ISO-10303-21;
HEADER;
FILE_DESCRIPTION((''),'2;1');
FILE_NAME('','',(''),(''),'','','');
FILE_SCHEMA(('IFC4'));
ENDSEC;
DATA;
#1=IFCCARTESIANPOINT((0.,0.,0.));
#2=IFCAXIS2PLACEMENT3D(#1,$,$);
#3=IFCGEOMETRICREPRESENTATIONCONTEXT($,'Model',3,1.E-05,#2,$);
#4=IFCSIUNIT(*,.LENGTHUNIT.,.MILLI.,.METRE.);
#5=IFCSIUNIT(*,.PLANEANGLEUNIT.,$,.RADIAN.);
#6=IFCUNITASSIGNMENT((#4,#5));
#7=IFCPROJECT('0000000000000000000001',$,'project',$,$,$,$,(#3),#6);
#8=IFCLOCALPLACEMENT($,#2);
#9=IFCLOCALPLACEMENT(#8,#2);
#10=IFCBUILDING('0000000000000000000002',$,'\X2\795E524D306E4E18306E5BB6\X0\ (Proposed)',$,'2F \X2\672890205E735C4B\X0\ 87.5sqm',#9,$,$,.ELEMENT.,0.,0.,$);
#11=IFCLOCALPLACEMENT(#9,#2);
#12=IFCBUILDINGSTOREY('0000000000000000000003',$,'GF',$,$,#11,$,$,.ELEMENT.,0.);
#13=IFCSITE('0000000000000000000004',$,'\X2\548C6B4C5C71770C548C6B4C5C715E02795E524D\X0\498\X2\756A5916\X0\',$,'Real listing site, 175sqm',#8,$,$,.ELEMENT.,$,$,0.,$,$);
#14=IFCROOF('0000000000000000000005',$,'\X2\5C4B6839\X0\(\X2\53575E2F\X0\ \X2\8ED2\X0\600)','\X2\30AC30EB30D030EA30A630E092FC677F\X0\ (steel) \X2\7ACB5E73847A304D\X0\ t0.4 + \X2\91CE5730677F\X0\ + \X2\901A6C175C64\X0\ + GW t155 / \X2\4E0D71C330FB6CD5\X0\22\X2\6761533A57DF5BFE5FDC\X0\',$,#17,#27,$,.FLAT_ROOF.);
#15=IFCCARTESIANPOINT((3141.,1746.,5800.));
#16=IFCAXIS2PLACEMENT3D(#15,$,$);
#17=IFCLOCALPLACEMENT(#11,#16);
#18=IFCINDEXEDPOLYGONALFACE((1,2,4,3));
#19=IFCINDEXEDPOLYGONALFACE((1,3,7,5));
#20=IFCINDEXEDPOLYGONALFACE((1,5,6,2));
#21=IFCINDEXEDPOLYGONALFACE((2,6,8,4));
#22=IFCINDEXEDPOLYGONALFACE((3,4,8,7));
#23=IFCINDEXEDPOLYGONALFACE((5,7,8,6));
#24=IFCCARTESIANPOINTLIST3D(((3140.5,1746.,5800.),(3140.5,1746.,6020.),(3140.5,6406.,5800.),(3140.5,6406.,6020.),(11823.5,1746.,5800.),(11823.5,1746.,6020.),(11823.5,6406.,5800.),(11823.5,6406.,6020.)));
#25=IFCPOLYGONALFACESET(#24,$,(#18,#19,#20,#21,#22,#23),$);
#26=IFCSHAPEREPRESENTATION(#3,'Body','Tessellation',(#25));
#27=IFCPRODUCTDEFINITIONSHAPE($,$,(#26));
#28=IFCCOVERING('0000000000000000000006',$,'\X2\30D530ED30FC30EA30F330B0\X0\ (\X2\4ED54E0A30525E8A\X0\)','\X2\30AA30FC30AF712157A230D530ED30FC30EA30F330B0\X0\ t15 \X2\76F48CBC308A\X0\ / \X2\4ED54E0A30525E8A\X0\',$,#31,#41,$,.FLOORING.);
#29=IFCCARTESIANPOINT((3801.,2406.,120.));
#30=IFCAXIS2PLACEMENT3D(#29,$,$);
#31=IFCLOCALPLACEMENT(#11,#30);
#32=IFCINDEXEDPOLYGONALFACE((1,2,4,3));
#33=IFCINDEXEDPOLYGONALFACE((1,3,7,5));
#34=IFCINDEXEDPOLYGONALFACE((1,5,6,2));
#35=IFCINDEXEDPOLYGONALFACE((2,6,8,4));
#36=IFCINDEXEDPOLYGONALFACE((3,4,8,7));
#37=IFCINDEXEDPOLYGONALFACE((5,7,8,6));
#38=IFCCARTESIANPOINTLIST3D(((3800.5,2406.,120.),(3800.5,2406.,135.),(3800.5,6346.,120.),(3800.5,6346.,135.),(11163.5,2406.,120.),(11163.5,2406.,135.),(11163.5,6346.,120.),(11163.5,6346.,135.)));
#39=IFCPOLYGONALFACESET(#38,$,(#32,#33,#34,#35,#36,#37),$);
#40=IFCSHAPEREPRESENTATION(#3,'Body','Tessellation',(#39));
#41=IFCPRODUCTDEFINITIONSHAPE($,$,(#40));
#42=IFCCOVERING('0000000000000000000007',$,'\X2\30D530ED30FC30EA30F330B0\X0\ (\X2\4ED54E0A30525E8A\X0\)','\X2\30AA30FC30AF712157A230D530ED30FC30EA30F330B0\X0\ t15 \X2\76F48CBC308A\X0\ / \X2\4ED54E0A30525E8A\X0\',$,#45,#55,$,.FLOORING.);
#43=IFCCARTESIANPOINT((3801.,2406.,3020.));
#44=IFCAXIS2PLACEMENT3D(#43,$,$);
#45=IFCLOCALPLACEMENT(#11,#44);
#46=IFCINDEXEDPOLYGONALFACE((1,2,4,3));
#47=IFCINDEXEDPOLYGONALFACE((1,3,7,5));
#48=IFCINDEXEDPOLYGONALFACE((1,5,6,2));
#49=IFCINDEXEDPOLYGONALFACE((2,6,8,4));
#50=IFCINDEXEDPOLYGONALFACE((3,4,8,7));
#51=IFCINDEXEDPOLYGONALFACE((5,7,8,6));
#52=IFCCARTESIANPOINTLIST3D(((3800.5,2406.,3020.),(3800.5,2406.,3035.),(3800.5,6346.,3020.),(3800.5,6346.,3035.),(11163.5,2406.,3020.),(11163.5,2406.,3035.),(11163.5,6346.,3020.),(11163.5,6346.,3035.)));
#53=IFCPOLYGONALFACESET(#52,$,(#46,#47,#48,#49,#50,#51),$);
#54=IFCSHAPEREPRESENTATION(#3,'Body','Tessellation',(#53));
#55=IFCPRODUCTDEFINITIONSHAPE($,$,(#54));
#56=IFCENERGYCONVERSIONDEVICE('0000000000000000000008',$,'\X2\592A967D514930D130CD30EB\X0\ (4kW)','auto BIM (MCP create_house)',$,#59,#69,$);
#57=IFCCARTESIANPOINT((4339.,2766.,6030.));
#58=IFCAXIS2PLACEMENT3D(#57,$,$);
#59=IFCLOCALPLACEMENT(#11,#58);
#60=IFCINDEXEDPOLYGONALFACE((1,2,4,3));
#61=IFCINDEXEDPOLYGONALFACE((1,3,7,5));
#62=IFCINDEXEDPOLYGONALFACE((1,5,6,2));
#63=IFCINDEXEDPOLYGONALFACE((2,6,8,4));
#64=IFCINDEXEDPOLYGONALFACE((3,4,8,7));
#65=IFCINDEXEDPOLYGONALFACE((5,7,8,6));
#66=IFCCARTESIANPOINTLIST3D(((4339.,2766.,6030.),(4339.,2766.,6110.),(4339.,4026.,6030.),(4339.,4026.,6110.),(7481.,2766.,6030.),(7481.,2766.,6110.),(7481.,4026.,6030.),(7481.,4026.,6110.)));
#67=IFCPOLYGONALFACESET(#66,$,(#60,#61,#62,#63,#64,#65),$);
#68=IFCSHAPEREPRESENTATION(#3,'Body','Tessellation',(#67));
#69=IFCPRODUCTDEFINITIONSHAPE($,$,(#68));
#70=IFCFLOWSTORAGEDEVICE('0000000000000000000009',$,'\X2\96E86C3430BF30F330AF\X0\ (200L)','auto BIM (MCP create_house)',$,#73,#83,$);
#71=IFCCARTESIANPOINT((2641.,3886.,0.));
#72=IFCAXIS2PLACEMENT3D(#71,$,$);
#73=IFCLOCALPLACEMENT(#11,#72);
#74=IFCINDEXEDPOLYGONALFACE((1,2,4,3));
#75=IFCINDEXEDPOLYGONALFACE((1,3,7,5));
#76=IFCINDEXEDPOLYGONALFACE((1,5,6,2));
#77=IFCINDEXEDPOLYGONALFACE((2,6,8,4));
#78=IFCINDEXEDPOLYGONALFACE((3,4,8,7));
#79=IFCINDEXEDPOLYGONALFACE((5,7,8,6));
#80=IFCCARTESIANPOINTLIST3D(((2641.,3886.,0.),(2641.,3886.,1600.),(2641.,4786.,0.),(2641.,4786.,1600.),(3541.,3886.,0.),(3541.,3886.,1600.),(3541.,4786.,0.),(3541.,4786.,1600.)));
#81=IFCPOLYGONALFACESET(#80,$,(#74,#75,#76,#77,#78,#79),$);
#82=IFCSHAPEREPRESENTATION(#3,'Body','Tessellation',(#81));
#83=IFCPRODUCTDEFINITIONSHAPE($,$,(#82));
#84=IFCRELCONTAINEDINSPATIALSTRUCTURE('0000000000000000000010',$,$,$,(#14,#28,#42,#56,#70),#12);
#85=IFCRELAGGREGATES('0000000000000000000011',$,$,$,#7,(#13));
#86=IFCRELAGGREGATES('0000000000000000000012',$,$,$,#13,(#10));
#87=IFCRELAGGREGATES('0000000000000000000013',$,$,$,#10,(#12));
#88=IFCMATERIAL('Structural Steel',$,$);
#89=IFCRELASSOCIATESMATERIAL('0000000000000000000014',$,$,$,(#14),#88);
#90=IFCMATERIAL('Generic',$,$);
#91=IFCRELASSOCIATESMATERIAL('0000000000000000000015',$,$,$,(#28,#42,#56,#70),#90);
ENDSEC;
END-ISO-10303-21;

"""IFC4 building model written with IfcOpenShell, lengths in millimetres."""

from ifc_helpers import new_model, si_unit, frame, frame_2d, origin, place, context, project, spatial, rectangle, extrude, material, element, save


model = new_model("IFC4")

# Units and contexts
model_context = context("Model", 3, precision=1e-05, world=origin())
ifc_project = project(units=[si_unit("LENGTHUNIT", "METRE", prefix="MILLI"), si_unit("PLANEANGLEUNIT", "RADIAN")], contexts=[model_context])

# Site, building, storey
site_placement = place(None, origin())
site = spatial("IfcSite", under=ifc_project, at=site_placement, Name="和歌山県和歌山市神前498番外", ObjectType="Real listing site, 175sqm", CompositionType="ELEMENT", RefElevation=0.0)
building_placement = place(site_placement, origin())
building = spatial("IfcBuilding", under=site, at=building_placement, Name="神前の丘の家 (Proposed)", ObjectType="2F 木造平屋 87.5sqm", CompositionType="ELEMENT", ElevationOfRefHeight=0.0, ElevationOfTerrain=0.0)
storey_placement = place(building_placement, origin())
storey = spatial("IfcBuildingStorey", under=building, at=storey_placement, Name="GF", CompositionType="ELEMENT", Elevation=0.0)

# Roof
ifc_material_1 = material(Name="Structural Steel")
for number, where, name in (
    (1, (3141.0, 1746.0, 5800.0), "屋根(南帯 軒600)"),
):
    element("IfcRoof", number, at=place(storey_placement, frame(where)), inside=storey, material=ifc_material_1, Name=name, Description="ガルバリウム鋼板 (steel) 立平葺き t0.4 + 野地板 + 通気層 + GW t155 / 不燃・法22条区域対応", PredefinedType="FLAT_ROOF", context=model_context, shape_type="SweptSolid", body=[
        extrude(rectangle(XDim=8683.0, YDim=4660.0, at=frame_2d((4341.0, 2330.0))), frame((3141.0, 1746.0, 5800.0)), (0.0, 0.0, 1.0), 220.0),
    ])

# Coverings
ifc_material_2 = material(Name="Generic")
covering_1_placement = place(storey_placement, frame((3801.0, 2406.0, 120.0)))
element("IfcCovering", 2, at=covering_1_placement, inside=storey, material=ifc_material_2, Name="フローリング (仕上げ床)", Description="オーク無垢フローリング t15 直貼り / 仕上げ床", PredefinedType="FLOORING", context=model_context, shape_type="SweptSolid", body=[
    extrude(rectangle(XDim=7363.0, YDim=3940.0, at=frame_2d((3681.0, 1970.0))), frame((3801.0, 2406.0, 120.0)), (0.0, 0.0, 1.0), 15.0),
])
covering_2_placement = place(storey_placement, frame((3801.0, 2406.0, 3020.0)))
element("IfcCovering", 3, at=covering_2_placement, inside=storey, material=ifc_material_2, Name="フローリング (仕上げ床)", Description="オーク無垢フローリング t15 直貼り / 仕上げ床", PredefinedType="FLOORING", context=model_context, shape_type="SweptSolid", body=[
    extrude(rectangle(XDim=7363.0, YDim=3940.0, at=frame_2d((3681.0, 1970.0))), frame((3801.0, 2406.0, 3020.0)), (0.0, 0.0, 1.0), 15.0),
])

# Energy conversion device
energy_conversion_device_placement = place(storey_placement, frame((4339.0, 2766.0, 6030.0)))
element("IfcEnergyConversionDevice", 4, at=energy_conversion_device_placement, inside=storey, material=ifc_material_2, Name="太陽光パネル (4kW)", Description="auto BIM (MCP create_house)", context=model_context, shape_type="SweptSolid", body=[
    extrude(rectangle(XDim=3142.0, YDim=1260.0, at=frame_2d((1571.0, 630.0))), frame((4339.0, 2766.0, 6030.0)), (0.0, 0.0, 1.0), 80.0),
])

# Flow storage device
flow_storage_device_placement = place(storey_placement, frame((2641.0, 3886.0, 0.0)))
element("IfcFlowStorageDevice", 5, at=flow_storage_device_placement, inside=storey, material=ifc_material_2, Name="雨水タンク (200L)", Description="auto BIM (MCP create_house)", context=model_context, shape_type="SweptSolid", body=[
    extrude(rectangle(XDim=900.0, YDim=900.0, at=frame_2d((450.0, 450.0))), frame((2641.0, 3886.0, 0.0)), (0.0, 0.0, 1.0), 1600.0),
])

save(model, "model.ifc")
